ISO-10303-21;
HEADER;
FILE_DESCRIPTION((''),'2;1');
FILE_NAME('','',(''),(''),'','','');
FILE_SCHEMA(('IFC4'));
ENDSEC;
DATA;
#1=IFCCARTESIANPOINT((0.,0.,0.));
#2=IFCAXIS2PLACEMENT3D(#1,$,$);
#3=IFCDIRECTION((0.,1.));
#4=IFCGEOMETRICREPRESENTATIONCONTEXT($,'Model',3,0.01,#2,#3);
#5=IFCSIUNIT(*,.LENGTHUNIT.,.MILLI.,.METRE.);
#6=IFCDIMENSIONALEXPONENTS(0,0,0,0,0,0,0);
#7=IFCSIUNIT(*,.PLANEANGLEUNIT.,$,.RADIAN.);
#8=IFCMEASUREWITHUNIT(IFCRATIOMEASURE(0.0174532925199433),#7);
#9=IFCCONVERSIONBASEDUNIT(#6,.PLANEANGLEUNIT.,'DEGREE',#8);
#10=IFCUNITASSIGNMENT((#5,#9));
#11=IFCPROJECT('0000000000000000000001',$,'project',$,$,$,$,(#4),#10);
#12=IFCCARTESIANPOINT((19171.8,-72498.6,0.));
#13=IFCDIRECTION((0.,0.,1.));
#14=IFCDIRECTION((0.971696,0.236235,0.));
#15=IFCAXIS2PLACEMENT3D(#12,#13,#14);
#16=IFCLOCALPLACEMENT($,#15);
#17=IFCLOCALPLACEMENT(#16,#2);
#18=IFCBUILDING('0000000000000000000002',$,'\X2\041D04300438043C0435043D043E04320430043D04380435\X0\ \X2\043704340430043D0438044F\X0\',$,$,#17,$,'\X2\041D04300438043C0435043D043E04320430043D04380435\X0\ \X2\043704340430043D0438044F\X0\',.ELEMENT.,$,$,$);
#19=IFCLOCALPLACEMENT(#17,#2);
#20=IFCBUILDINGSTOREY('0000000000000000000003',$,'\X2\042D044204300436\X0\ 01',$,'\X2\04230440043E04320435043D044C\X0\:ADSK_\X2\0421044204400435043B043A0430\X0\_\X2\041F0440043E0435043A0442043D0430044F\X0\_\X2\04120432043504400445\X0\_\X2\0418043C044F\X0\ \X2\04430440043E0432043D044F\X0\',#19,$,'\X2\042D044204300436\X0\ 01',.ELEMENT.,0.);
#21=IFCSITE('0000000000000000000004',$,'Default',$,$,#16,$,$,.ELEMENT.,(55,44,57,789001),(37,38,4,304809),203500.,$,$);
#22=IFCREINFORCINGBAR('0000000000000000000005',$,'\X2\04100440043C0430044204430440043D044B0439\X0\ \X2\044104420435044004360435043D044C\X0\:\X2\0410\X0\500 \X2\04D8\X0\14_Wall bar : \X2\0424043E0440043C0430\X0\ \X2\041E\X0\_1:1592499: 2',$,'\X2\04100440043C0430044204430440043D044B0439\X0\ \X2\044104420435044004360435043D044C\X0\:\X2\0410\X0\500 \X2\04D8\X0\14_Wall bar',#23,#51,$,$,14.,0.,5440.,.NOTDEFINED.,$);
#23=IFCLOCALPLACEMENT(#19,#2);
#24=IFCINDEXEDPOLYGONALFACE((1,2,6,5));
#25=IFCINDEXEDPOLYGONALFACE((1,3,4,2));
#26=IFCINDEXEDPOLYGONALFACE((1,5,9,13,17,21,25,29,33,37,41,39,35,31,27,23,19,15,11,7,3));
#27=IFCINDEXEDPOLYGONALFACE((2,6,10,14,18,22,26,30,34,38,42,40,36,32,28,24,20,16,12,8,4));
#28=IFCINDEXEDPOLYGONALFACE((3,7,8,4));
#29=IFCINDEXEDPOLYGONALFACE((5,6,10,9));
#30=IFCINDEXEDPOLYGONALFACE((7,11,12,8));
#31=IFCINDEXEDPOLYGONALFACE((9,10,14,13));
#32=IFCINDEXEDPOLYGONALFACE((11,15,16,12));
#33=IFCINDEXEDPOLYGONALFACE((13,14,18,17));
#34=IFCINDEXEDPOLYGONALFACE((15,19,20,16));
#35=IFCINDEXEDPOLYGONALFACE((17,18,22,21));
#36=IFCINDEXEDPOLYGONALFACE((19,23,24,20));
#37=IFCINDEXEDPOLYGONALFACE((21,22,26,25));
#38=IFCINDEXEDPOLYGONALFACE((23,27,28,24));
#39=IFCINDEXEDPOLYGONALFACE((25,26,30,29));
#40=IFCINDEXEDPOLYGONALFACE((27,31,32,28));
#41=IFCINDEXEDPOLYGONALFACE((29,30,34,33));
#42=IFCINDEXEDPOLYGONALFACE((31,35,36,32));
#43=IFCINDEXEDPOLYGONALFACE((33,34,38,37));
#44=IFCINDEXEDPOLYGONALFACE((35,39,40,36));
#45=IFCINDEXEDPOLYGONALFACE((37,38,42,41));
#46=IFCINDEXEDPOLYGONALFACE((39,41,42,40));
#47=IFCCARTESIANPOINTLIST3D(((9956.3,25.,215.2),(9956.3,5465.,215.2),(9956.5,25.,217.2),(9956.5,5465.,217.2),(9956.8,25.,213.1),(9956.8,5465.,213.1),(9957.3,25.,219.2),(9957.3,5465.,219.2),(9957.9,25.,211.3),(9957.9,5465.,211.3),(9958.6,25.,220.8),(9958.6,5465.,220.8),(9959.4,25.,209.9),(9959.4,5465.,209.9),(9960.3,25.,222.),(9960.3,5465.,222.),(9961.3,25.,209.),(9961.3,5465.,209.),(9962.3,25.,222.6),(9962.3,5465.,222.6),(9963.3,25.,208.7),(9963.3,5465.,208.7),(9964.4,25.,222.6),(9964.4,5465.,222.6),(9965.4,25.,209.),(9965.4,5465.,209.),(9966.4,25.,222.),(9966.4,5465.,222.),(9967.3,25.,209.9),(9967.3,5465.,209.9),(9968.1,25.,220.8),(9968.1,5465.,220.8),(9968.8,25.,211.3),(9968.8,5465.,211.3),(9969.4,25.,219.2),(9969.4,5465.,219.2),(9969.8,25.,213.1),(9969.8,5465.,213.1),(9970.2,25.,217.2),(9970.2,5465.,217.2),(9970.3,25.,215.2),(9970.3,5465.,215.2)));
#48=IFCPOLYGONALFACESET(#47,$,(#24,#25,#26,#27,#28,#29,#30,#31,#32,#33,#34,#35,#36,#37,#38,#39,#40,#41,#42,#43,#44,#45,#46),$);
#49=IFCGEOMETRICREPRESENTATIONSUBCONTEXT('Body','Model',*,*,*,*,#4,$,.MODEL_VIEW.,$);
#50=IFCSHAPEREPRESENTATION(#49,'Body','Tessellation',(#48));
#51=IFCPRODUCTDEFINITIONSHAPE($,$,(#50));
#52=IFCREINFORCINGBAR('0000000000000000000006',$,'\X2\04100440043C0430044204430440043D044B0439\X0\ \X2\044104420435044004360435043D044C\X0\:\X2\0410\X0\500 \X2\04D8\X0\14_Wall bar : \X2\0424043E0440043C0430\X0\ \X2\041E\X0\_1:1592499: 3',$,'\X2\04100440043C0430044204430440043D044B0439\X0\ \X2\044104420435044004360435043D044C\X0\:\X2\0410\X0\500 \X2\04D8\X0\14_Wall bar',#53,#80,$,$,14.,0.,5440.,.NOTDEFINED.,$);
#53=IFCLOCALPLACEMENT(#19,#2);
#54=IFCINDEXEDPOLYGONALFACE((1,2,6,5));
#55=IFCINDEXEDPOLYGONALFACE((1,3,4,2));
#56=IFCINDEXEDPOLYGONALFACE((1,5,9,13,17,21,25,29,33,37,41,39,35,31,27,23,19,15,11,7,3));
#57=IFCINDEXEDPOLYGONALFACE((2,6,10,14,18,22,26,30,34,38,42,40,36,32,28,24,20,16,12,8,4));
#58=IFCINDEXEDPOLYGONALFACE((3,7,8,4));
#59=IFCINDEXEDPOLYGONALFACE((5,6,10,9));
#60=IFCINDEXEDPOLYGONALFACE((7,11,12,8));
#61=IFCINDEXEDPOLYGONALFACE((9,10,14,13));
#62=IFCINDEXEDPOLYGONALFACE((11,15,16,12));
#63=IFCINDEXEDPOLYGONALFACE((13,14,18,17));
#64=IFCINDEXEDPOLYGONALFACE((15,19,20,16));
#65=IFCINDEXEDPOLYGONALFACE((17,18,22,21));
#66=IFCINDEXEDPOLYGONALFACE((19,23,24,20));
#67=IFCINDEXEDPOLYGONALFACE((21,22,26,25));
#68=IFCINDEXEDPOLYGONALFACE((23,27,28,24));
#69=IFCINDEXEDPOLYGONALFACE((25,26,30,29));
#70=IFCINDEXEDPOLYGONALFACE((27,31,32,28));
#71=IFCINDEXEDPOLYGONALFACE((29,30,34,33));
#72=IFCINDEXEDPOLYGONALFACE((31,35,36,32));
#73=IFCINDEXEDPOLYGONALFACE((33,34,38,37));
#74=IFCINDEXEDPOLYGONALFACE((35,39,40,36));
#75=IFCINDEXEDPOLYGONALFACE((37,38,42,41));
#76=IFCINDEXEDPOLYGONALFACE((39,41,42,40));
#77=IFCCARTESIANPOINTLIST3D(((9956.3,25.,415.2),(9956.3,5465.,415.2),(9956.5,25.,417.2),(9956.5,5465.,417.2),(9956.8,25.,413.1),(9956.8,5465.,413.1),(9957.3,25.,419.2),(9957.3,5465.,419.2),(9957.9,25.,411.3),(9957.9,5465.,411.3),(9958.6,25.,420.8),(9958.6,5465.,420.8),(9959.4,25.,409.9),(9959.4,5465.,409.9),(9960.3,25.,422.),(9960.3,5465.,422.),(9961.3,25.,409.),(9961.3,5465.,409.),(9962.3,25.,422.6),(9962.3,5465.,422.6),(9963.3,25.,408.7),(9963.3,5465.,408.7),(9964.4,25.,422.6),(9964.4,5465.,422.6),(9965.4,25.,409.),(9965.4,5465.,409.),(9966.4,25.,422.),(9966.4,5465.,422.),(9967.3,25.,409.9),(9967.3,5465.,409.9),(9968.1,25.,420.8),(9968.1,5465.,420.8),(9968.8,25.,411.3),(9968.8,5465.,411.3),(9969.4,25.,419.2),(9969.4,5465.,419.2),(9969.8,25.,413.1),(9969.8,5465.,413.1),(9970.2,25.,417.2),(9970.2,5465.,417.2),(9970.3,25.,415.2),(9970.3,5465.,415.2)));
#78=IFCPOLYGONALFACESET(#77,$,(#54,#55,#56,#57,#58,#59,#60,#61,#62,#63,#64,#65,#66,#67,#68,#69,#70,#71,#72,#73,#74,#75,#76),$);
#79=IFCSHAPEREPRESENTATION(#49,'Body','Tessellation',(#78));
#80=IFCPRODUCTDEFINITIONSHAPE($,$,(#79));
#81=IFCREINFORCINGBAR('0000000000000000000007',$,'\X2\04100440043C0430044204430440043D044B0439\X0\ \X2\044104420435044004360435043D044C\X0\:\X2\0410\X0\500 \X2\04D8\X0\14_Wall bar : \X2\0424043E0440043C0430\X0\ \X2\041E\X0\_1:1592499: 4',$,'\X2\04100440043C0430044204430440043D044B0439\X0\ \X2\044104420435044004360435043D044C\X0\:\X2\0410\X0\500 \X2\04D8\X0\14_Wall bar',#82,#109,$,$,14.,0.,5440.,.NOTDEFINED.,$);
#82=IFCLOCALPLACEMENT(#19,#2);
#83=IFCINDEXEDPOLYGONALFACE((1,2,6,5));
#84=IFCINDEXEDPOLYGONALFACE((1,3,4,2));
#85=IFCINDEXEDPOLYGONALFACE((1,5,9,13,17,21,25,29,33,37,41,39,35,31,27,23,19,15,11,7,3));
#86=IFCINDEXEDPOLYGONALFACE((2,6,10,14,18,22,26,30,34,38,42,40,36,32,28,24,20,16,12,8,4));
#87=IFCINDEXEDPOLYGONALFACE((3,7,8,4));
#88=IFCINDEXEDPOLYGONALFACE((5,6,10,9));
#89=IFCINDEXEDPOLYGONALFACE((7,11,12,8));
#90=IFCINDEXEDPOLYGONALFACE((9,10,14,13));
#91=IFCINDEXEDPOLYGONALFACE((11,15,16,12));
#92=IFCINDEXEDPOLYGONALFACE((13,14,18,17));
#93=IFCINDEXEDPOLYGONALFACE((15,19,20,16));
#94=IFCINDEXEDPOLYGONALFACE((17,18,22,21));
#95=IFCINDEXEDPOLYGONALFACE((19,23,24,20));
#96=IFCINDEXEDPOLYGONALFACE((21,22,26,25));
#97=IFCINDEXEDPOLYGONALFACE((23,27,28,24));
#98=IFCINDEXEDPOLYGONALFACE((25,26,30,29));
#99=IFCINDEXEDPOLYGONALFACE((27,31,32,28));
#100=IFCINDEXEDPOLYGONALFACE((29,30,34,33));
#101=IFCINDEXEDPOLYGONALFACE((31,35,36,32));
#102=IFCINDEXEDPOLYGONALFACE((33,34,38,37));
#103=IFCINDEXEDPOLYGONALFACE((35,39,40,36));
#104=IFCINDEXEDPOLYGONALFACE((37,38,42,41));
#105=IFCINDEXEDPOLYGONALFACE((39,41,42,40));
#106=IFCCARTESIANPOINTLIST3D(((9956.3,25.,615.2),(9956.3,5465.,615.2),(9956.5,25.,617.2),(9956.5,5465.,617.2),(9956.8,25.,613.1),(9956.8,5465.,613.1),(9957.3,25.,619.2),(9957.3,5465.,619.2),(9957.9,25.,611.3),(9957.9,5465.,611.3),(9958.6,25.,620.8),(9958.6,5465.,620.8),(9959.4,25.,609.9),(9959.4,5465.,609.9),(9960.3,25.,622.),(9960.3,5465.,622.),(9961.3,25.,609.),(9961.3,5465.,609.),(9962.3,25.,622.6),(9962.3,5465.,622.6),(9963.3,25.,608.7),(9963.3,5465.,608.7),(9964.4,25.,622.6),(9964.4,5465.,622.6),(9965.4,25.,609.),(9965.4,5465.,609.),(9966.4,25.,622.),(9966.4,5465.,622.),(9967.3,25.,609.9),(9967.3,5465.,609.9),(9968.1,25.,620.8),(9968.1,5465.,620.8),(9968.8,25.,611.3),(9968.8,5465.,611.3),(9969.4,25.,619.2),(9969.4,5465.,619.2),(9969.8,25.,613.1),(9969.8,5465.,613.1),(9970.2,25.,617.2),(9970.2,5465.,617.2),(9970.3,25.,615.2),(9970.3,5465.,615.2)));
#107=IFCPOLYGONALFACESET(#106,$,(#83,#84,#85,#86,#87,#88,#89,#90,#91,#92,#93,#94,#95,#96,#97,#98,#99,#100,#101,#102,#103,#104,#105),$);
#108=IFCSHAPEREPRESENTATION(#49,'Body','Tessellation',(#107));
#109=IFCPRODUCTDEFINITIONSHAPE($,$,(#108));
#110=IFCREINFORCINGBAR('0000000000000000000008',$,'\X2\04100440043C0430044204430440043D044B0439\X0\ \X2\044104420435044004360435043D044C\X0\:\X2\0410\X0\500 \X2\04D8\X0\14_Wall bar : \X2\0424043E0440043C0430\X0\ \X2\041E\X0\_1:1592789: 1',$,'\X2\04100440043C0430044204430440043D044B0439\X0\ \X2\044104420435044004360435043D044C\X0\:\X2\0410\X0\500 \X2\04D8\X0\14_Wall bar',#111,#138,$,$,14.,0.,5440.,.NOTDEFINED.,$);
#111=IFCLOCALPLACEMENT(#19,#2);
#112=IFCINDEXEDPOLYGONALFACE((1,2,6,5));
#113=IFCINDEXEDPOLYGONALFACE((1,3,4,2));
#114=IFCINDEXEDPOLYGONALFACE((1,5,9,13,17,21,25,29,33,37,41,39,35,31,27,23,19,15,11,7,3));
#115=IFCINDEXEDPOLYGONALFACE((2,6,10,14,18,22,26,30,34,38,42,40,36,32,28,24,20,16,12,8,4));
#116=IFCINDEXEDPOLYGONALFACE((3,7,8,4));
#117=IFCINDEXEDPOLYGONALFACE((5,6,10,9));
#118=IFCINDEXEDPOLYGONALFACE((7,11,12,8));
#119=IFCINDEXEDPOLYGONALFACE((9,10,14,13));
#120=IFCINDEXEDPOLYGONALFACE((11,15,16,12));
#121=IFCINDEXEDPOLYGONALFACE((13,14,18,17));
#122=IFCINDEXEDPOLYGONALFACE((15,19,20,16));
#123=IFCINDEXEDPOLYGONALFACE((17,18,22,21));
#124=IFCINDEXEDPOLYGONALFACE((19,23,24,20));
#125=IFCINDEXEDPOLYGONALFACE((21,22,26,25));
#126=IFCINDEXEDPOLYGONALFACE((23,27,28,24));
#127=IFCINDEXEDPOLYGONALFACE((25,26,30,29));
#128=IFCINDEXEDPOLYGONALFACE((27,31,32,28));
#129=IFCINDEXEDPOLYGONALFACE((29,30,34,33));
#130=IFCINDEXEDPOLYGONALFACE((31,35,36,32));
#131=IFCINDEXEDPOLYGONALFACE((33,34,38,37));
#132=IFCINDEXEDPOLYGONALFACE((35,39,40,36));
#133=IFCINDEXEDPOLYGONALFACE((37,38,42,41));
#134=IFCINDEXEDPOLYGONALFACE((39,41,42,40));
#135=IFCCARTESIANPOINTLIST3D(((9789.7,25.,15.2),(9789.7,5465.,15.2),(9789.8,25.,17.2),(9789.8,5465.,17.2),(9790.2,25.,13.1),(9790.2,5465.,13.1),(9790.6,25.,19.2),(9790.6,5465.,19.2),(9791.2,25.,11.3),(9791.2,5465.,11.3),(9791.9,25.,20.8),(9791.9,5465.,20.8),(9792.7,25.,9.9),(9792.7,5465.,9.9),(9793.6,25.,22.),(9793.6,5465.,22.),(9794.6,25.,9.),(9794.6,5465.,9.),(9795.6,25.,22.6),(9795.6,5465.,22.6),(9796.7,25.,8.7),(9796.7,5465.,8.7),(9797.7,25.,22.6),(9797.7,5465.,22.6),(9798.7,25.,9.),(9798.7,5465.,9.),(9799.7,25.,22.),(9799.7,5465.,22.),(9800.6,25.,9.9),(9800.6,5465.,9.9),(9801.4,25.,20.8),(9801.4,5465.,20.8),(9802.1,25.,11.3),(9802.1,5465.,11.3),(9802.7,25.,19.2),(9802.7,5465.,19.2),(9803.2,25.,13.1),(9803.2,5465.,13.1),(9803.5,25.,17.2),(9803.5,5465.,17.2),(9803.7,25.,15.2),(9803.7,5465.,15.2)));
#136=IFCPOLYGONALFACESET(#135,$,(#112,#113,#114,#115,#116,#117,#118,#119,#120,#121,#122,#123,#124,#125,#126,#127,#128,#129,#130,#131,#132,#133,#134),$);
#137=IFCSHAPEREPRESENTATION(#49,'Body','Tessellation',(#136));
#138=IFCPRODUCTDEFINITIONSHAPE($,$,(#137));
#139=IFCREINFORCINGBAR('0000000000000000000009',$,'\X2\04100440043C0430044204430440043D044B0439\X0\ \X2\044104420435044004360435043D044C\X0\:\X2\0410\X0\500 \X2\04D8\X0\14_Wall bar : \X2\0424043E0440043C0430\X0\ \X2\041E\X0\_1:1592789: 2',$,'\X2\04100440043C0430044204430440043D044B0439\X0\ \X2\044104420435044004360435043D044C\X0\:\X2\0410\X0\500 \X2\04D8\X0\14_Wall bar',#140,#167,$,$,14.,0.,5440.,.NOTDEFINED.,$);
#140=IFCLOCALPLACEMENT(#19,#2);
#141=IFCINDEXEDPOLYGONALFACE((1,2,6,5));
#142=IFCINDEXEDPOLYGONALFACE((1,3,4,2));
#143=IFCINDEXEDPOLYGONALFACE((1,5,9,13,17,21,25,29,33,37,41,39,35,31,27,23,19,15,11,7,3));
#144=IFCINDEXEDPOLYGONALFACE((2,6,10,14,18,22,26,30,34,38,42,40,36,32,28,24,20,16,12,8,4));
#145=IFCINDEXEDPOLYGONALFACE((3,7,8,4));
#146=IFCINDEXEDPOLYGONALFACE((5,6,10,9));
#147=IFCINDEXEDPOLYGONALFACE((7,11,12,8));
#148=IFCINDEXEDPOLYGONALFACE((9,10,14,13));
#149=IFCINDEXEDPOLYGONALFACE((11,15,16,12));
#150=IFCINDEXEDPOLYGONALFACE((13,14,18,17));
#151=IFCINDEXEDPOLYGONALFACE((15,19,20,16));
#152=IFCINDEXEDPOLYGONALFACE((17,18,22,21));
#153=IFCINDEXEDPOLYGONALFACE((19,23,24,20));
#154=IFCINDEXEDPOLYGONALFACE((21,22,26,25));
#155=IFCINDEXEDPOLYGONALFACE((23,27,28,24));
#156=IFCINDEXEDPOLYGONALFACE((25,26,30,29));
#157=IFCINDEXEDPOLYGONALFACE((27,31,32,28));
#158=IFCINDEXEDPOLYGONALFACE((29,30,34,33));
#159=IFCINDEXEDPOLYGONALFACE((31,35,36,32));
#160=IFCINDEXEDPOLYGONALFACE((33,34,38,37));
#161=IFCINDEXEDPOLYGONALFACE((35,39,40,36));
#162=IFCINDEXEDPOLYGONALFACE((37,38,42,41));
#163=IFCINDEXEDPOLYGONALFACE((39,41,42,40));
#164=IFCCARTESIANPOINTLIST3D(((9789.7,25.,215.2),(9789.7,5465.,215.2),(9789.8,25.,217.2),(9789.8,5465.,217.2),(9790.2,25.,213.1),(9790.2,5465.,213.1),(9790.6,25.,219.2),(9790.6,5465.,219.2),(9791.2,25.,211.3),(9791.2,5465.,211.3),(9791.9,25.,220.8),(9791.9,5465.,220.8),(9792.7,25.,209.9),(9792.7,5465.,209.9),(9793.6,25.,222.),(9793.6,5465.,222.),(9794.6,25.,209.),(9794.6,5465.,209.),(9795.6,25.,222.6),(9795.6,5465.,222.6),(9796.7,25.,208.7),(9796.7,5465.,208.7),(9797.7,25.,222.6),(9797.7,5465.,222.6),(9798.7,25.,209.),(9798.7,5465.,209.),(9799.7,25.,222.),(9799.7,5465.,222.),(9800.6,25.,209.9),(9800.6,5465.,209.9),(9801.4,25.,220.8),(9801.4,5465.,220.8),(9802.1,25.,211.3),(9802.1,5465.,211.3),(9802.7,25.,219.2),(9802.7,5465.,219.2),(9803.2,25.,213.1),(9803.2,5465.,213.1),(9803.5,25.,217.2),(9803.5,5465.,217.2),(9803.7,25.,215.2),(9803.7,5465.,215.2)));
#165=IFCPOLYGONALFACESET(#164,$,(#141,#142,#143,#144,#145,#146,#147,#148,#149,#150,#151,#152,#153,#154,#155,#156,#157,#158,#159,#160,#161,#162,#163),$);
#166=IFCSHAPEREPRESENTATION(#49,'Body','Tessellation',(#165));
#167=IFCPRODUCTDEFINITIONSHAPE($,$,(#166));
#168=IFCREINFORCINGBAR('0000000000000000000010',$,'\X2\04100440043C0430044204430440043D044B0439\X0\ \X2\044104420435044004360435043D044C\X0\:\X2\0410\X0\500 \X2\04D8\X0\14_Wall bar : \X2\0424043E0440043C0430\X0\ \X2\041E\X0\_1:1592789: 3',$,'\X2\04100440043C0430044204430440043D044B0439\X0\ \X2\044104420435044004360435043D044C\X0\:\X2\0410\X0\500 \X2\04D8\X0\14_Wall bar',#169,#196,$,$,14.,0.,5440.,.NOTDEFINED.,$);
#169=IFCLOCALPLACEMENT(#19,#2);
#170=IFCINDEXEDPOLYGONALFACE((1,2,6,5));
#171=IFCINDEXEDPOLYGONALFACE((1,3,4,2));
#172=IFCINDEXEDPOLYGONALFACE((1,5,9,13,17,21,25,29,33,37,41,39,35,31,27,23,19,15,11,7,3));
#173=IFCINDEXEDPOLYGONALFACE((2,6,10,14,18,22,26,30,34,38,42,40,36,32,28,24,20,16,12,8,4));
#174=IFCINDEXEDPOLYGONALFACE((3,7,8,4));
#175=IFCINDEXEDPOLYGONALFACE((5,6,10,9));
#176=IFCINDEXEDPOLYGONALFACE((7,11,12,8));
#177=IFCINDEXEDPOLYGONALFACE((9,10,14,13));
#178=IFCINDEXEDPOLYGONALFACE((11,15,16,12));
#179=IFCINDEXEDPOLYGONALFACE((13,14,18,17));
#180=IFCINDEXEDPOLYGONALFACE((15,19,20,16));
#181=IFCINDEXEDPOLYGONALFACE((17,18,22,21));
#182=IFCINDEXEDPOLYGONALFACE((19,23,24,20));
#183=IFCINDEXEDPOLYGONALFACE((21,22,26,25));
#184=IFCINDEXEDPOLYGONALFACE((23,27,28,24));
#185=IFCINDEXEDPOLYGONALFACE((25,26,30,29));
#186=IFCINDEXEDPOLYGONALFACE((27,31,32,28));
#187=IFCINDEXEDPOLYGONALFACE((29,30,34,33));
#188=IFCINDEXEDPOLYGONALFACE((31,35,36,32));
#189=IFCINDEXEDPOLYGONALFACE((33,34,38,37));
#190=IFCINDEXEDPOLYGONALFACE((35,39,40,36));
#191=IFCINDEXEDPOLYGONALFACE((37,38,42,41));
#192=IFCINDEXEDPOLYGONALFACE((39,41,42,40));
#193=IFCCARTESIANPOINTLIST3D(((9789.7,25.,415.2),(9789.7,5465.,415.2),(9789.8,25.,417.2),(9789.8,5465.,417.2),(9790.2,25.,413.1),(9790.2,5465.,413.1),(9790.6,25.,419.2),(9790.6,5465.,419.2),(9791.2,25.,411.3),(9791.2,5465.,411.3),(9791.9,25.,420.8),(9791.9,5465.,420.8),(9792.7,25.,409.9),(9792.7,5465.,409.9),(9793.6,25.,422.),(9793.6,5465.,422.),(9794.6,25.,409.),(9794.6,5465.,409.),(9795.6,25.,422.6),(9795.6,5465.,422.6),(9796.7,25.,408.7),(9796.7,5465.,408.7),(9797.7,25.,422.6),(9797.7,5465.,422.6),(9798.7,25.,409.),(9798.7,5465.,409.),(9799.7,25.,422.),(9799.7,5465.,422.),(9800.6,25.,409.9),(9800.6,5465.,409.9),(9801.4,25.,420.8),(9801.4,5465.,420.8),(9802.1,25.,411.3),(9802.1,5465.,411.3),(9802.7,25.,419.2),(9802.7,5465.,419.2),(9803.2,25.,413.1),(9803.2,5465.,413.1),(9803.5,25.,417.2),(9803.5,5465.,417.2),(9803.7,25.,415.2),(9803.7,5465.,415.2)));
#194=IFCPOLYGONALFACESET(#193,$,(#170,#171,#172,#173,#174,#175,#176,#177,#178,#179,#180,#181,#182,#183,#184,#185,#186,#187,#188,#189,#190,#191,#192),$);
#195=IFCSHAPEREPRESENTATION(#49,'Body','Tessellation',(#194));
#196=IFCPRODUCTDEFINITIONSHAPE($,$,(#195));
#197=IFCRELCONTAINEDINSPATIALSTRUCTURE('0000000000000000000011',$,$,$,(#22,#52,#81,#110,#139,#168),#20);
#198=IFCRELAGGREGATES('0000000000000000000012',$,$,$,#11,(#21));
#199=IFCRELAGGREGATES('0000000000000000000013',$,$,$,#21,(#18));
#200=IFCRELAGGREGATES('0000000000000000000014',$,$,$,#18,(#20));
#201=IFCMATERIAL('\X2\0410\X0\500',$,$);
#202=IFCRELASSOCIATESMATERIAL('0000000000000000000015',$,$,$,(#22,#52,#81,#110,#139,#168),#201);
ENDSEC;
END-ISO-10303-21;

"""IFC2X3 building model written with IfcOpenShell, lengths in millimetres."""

from ifc_helpers import new_model, entity, si_unit, converted_unit, direction, frame, origin, place, context, subcontext, project, spatial, material, element, save


model = new_model("IFC2X3")

# Units and contexts
model_context = context("Model", 3, precision=0.01, world=origin(), true_north=direction((0.0, 1.0)))
body_context = subcontext(model_context, "Body", "Model", "MODEL_VIEW")
ifc_project = project(units=[si_unit("LENGTHUNIT", "METRE", prefix="MILLI"), converted_unit("PLANEANGLEUNIT", "DEGREE", entity("IfcRatioMeasure", 0.0174532925199433), si_unit("PLANEANGLEUNIT", "RADIAN"), dimensions=[0, 0, 0, 0, 0, 0, 0])], contexts=[model_context])

# Site, building, storey
site_placement = place(None, frame((19171.8, -72498.6, 0.0), z_axis=(0.0, 0.0, 1.0), x_axis=(0.971696, 0.236235, 0.0)))
site = spatial("IfcSite", under=ifc_project, at=site_placement, Name="Default", CompositionType="ELEMENT", RefLatitude=(55, 44, 57, 789001), RefLongitude=(37, 38, 4, 304809), RefElevation=203500.0)
building_placement = place(site_placement, origin())
building = spatial("IfcBuilding", under=site, at=building_placement, Name="Наименование здания", LongName="Наименование здания", CompositionType="ELEMENT")
storey_placement = place(building_placement, origin())
storey = spatial("IfcBuildingStorey", under=building, at=storey_placement, Name="Этаж 01", ObjectType="Уровень:ADSK_Стрелка_Проектная_Вверх_Имя уровня", LongName="Этаж 01", CompositionType="ELEMENT", Elevation=0.0)

# Reinforcing bars
ifc_material = material(Name="А500")
placement = place(storey_placement, origin())
element("IfcReinforcingBar", 1, at=placement, inside=storey, material=ifc_material, Name="Арматурный стержень:А500 Ә14_Wall bar : Форма О_1:1592499: 2", ObjectType="Арматурный стержень:А500 Ә14_Wall bar", BarLength=5440.0, BarRole="NOTDEFINED", CrossSectionArea=0.0, NominalDiameter=14.0, context=body_context, shape_type="AdvancedSweptSolid", body=[
    entity("IfcSweptDiskSolid", entity("IfcCompositeCurve", [entity("IfcCompositeCurveSegment", "CONTINUOUS", True, entity("IfcPolyline", [entity("IfcCartesianPoint", [9963.3, 5465.0, 215.7]), entity("IfcCartesianPoint", [9963.3, 25.0, 215.7])]))], False), 7.0, None, 0.0, 1.0),
])
element("IfcReinforcingBar", 2, at=placement, inside=storey, material=ifc_material, Name="Арматурный стержень:А500 Ә14_Wall bar : Форма О_1:1592499: 3", ObjectType="Арматурный стержень:А500 Ә14_Wall bar", BarLength=5440.0, BarRole="NOTDEFINED", CrossSectionArea=0.0, NominalDiameter=14.0, context=body_context, shape_type="AdvancedSweptSolid", body=[
    entity("IfcSweptDiskSolid", entity("IfcCompositeCurve", [entity("IfcCompositeCurveSegment", "CONTINUOUS", True, entity("IfcPolyline", [entity("IfcCartesianPoint", [9963.3, 5465.0, 415.7]), entity("IfcCartesianPoint", [9963.3, 25.0, 415.7])]))], False), 7.0, None, 0.0, 1.0),
])
element("IfcReinforcingBar", 3, at=placement, inside=storey, material=ifc_material, Name="Арматурный стержень:А500 Ә14_Wall bar : Форма О_1:1592499: 4", ObjectType="Арматурный стержень:А500 Ә14_Wall bar", BarLength=5440.0, BarRole="NOTDEFINED", CrossSectionArea=0.0, NominalDiameter=14.0, context=body_context, shape_type="AdvancedSweptSolid", body=[
    entity("IfcSweptDiskSolid", entity("IfcCompositeCurve", [entity("IfcCompositeCurveSegment", "CONTINUOUS", True, entity("IfcPolyline", [entity("IfcCartesianPoint", [9963.3, 5465.0, 615.7]), entity("IfcCartesianPoint", [9963.3, 25.0, 615.7])]))], False), 7.0, None, 0.0, 1.0),
])
element("IfcReinforcingBar", 4, at=placement, inside=storey, material=ifc_material, Name="Арматурный стержень:А500 Ә14_Wall bar : Форма О_1:1592789: 1", ObjectType="Арматурный стержень:А500 Ә14_Wall bar", BarLength=5440.0, BarRole="NOTDEFINED", CrossSectionArea=0.0, NominalDiameter=14.0, context=body_context, shape_type="AdvancedSweptSolid", body=[
    entity("IfcSweptDiskSolid", entity("IfcCompositeCurve", [entity("IfcCompositeCurveSegment", "CONTINUOUS", True, entity("IfcPolyline", [entity("IfcCartesianPoint", [9796.7, 5465.0, 15.7]), entity("IfcCartesianPoint", [9796.7, 25.0, 15.7])]))], False), 7.0, None, 0.0, 1.0),
])
element("IfcReinforcingBar", 5, at=placement, inside=storey, material=ifc_material, Name="Арматурный стержень:А500 Ә14_Wall bar : Форма О_1:1592789: 2", ObjectType="Арматурный стержень:А500 Ә14_Wall bar", BarLength=5440.0, BarRole="NOTDEFINED", CrossSectionArea=0.0, NominalDiameter=14.0, context=body_context, shape_type="AdvancedSweptSolid", body=[
    entity("IfcSweptDiskSolid", entity("IfcCompositeCurve", [entity("IfcCompositeCurveSegment", "CONTINUOUS", True, entity("IfcPolyline", [entity("IfcCartesianPoint", [9796.7, 5465.0, 215.7]), entity("IfcCartesianPoint", [9796.7, 25.0, 215.7])]))], False), 7.0, None, 0.0, 1.0),
])
element("IfcReinforcingBar", 6, at=placement, inside=storey, material=ifc_material, Name="Арматурный стержень:А500 Ә14_Wall bar : Форма О_1:1592789: 3", ObjectType="Арматурный стержень:А500 Ә14_Wall bar", BarLength=5440.0, BarRole="NOTDEFINED", CrossSectionArea=0.0, NominalDiameter=14.0, context=body_context, shape_type="AdvancedSweptSolid", body=[
    entity("IfcSweptDiskSolid", entity("IfcCompositeCurve", [entity("IfcCompositeCurveSegment", "CONTINUOUS", True, entity("IfcPolyline", [entity("IfcCartesianPoint", [9796.7, 5465.0, 415.7]), entity("IfcCartesianPoint", [9796.7, 25.0, 415.7])]))], False), 7.0, None, 0.0, 1.0),
])

save(model, "model.ifc")
